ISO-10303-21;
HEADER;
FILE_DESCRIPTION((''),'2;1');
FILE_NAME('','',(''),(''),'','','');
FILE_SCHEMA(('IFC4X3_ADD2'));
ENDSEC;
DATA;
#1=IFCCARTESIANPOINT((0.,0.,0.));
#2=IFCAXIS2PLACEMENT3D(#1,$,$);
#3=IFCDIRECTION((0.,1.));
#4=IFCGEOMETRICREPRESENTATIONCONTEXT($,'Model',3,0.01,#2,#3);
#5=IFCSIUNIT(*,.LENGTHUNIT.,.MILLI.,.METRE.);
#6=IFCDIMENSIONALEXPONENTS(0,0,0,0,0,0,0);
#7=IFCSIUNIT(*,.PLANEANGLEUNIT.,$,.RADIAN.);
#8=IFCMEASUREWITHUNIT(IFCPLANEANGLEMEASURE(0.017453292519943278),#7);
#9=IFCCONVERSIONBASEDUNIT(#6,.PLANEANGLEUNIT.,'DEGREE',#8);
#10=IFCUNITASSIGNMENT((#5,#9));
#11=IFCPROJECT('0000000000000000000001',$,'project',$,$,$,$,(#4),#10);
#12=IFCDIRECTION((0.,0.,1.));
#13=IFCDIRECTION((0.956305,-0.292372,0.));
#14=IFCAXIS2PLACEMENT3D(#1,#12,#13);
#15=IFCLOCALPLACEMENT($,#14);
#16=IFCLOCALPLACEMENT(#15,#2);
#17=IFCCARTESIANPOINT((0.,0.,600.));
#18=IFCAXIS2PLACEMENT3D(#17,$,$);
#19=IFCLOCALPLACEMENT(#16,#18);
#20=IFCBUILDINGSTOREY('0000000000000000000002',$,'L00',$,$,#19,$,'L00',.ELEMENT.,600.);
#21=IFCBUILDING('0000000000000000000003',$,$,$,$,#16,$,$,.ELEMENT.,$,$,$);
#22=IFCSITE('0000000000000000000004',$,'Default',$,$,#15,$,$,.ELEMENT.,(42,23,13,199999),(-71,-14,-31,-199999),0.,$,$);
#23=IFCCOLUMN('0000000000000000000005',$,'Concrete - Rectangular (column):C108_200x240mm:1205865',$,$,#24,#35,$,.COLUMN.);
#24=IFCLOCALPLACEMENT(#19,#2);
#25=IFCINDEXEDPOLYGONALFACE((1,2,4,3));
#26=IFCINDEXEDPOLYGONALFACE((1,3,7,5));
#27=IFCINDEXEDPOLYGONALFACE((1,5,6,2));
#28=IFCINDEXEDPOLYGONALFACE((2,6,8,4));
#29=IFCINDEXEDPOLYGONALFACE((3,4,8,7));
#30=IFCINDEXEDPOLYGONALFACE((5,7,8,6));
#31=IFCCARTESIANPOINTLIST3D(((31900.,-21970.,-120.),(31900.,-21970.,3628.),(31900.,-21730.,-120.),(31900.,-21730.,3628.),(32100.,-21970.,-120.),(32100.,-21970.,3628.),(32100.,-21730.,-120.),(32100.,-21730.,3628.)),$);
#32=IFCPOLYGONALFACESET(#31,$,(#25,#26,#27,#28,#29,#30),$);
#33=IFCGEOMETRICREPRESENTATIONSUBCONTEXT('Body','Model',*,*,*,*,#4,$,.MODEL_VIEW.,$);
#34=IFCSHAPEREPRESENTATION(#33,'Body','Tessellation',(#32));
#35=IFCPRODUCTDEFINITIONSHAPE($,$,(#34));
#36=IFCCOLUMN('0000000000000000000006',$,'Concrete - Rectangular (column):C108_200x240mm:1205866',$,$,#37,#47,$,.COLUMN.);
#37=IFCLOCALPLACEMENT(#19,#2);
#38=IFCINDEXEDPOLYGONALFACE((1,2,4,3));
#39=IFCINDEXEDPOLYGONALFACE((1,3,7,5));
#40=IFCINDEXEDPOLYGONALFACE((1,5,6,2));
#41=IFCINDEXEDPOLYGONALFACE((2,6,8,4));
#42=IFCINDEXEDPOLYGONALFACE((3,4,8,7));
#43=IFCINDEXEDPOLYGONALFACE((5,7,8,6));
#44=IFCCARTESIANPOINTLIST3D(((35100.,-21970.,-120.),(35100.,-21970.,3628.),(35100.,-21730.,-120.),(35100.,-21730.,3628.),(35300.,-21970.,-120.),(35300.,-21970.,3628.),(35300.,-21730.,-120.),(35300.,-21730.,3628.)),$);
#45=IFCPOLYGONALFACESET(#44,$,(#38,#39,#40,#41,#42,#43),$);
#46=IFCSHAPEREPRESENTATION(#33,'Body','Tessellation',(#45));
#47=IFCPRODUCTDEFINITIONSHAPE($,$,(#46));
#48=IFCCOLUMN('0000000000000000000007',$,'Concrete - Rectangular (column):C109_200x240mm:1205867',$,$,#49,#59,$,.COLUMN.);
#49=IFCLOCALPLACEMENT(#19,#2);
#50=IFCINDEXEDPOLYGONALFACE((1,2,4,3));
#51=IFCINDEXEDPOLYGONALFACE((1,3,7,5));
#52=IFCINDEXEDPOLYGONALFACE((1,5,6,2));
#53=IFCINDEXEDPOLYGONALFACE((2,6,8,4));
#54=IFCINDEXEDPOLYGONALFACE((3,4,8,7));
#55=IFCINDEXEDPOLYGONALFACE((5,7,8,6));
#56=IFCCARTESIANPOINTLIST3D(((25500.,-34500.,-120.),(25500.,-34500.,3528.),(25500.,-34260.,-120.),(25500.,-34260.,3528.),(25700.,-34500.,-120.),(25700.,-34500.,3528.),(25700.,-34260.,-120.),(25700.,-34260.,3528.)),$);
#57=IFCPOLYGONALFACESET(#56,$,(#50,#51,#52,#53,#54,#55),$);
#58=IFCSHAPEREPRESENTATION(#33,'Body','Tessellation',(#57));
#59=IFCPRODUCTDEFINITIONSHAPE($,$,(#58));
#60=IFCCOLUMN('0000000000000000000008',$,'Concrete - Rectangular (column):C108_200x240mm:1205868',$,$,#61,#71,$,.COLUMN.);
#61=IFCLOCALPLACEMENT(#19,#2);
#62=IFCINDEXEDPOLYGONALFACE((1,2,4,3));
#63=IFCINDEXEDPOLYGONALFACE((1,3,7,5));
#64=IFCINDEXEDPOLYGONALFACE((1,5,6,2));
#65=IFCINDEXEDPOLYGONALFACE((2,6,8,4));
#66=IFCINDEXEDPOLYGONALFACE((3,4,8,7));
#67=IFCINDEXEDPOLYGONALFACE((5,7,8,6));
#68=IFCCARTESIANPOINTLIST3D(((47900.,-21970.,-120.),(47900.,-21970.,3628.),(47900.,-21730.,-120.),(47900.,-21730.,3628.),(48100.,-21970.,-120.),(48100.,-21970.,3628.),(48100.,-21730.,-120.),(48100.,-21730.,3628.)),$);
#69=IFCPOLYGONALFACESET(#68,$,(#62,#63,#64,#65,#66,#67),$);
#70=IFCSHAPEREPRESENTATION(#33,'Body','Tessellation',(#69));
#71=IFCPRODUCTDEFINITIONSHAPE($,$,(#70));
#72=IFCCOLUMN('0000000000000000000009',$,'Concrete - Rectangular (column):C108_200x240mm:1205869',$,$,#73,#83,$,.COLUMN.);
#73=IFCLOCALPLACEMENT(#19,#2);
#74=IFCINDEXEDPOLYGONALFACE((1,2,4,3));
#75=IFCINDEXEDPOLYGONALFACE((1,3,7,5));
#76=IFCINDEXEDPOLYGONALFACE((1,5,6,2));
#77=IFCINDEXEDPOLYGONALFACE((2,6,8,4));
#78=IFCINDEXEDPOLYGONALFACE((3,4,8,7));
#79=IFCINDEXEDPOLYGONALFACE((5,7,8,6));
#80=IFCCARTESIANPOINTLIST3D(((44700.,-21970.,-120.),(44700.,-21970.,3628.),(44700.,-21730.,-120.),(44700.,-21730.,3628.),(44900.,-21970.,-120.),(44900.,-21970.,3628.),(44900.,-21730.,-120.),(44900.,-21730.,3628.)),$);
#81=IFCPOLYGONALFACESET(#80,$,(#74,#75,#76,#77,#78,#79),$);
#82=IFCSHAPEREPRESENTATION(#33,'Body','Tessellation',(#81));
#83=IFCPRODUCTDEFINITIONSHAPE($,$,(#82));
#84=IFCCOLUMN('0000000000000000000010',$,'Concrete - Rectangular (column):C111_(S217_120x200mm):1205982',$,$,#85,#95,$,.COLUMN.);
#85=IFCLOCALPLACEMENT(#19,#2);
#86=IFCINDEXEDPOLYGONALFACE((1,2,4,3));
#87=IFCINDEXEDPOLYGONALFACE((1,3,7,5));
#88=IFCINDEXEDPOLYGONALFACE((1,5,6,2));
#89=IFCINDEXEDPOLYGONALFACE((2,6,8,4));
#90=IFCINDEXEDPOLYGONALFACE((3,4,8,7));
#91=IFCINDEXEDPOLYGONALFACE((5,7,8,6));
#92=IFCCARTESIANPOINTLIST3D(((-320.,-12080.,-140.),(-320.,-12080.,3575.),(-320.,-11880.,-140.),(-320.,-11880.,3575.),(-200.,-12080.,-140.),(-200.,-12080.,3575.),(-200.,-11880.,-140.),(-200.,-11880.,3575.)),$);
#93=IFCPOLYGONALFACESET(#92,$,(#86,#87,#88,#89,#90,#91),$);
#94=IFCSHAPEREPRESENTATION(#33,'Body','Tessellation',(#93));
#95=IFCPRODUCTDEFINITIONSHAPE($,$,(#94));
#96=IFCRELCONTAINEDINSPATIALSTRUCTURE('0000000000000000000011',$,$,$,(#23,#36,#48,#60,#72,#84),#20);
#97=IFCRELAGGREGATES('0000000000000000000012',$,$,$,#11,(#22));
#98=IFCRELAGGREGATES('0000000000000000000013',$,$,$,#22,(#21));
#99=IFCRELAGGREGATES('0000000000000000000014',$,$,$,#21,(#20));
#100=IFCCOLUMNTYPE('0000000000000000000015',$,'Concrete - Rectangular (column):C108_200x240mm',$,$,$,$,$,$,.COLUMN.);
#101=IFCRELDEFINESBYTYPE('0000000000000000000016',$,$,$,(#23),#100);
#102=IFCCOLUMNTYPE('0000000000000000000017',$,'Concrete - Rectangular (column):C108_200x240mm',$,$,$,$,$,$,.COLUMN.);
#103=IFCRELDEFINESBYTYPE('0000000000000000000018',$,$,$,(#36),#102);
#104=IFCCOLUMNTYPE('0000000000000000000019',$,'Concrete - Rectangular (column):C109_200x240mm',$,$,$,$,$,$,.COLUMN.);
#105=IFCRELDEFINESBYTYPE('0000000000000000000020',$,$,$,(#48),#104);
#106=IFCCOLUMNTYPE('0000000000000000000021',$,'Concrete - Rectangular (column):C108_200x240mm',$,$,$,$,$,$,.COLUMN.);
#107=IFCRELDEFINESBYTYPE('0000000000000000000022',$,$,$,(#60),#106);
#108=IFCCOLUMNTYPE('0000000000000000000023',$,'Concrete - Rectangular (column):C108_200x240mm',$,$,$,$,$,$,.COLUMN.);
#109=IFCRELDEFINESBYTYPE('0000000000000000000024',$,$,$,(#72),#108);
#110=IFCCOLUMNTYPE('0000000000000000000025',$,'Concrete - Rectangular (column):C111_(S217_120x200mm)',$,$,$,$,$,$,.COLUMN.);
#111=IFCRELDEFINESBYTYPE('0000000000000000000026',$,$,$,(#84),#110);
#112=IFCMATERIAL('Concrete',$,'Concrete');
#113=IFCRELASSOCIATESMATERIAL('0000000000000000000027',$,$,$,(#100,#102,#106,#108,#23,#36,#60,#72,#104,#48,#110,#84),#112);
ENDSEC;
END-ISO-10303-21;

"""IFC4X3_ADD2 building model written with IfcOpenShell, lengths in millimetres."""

from ifc_helpers import new_model, entity, si_unit, converted_unit, direction, frame, frame_2d, origin, origin_2d_with_axis, place, context, subcontext, project, spatial, rectangle, extrude, source, transform, mapped, material, material_profile, profile_set, profile_usage, type_object, type_shapes, element, save


model = new_model("IFC4X3_ADD2")

# Units and contexts
model_context = context("Model", 3, precision=0.01, world=origin(), true_north=direction((0.0, 1.0)))
body_context = subcontext(model_context, "Body", "Model", "MODEL_VIEW")
ifc_project = project(units=[si_unit("LENGTHUNIT", "METRE", prefix="MILLI"), converted_unit("PLANEANGLEUNIT", "DEGREE", entity("IfcPlaneAngleMeasure", 0.017453292519943278), si_unit("PLANEANGLEUNIT", "RADIAN"), dimensions=[0, 0, 0, 0, 0, 0, 0])], contexts=[model_context])

# Site, building, storey
site_placement = place(None, frame((0.0, 0.0, 0.0), z_axis=(0.0, 0.0, 1.0), x_axis=(0.956305, -0.292372, 0.0)))
site = spatial("IfcSite", under=ifc_project, at=site_placement, Name="Default", CompositionType="ELEMENT", RefLatitude=(42, 23, 13, 199999), RefLongitude=(-71, -14, -31, -199999), RefElevation=0.0)
building_placement = place(site_placement, origin())
building = spatial("IfcBuilding", under=site, at=building_placement, CompositionType="ELEMENT")
storey_placement = place(building_placement, frame((0.0, 0.0, 600.0)))
storey = spatial("IfcBuildingStorey", under=building, at=storey_placement, Name="L00", LongName="L00", CompositionType="ELEMENT", Elevation=600.0)

# Columns
ifc_material_1 = material(Name="Concrete", Category="Concrete")
ifc_material_profile_1 = material_profile(ifc_material_1, rectangle(XDim=200.0, YDim=240.0, at=frame_2d((0.0, 0.0), x_axis=(1.0, 0.0))), Name="C108_200x240mm")
ifc_profile_set_1 = profile_set([ifc_material_profile_1], Name="C108_200x240mm")
ifc_profile_usage_1 = profile_usage(ifc_profile_set_1)
column_type_1 = type_object("IfcColumnType", Name="Concrete - Rectangular (column):C108_200x240mm", PredefinedType="COLUMN", material=ifc_profile_set_1)
shared_shape_1 = source(origin(), body_context, "Body", "SweptSolid", [
    extrude(rectangle(XDim=200.0, YDim=240.0, at=frame_2d((0.0, 0.0), x_axis=(1.0, 0.0))), frame((32000.0, -21850.0, 480.0), z_axis=(0.0, 0.0, 1.0), x_axis=(-1.0, 0.0, 0.0)), (0.0, 0.0, 1.0), 3748.0),
])
type_shapes(column_type_1, [shared_shape_1])
column_1_placement = place(storey_placement, frame((0.0, 0.0, -600.0)))
element("IfcColumn", 1, at=column_1_placement, inside=storey, type_object=column_type_1, material=ifc_profile_usage_1, Name="Concrete - Rectangular (column):C108_200x240mm:1205865", PredefinedType="COLUMN", context=body_context, shape_type="MappedRepresentation", body=[
    mapped(shared_shape_1, transform((0.0, 0.0, 0.0), scale=1.0)),
])
column_type_2 = type_object("IfcColumnType", Name="Concrete - Rectangular (column):C108_200x240mm", PredefinedType="COLUMN", material=ifc_profile_set_1)
shared_shape_2 = source(origin(), body_context, "Body", "SweptSolid", [
    extrude(rectangle(XDim=200.0, YDim=240.0, at=frame_2d((0.0, 0.0), x_axis=(1.0, 0.0))), frame((35200.0, -21850.0, 480.0), z_axis=(0.0, 0.0, 1.0), x_axis=(-1.0, 0.0, 0.0)), (0.0, 0.0, 1.0), 3748.0),
])
type_shapes(column_type_2, [shared_shape_2])
column_2_placement = place(storey_placement, frame((0.0, 0.0, -600.0)))
element("IfcColumn", 2, at=column_2_placement, inside=storey, type_object=column_type_2, material=ifc_profile_usage_1, Name="Concrete - Rectangular (column):C108_200x240mm:1205866", PredefinedType="COLUMN", context=body_context, shape_type="MappedRepresentation", body=[
    mapped(shared_shape_2, transform((0.0, 0.0, 0.0), scale=1.0)),
])
ifc_material_profile_2 = material_profile(ifc_material_1, rectangle(XDim=200.0, YDim=240.0, at=frame_2d((0.0, 0.0), x_axis=(1.0, 0.0))), Name="C109_200x240mm")
ifc_profile_set_2 = profile_set([ifc_material_profile_2], Name="C109_200x240mm")
ifc_profile_usage_2 = profile_usage(ifc_profile_set_2)
column_type_3 = type_object("IfcColumnType", Name="Concrete - Rectangular (column):C109_200x240mm", PredefinedType="COLUMN", material=ifc_profile_set_2)
shared_shape_3 = source(origin(), body_context, "Body", "SweptSolid", [
    extrude(rectangle(XDim=200.0, YDim=240.0, at=frame_2d((0.0, 0.0), x_axis=(1.0, 0.0))), frame((25600.0, -34380.0, 480.0), z_axis=(0.0, 0.0, 1.0), x_axis=(-1.0, 0.0, 0.0)), (0.0, 0.0, 1.0), 3648.0),
])
type_shapes(column_type_3, [shared_shape_3])
column_3_placement = place(storey_placement, frame((0.0, 0.0, -600.0)))
element("IfcColumn", 3, at=column_3_placement, inside=storey, type_object=column_type_3, material=ifc_profile_usage_2, Name="Concrete - Rectangular (column):C109_200x240mm:1205867", PredefinedType="COLUMN", context=body_context, shape_type="MappedRepresentation", body=[
    mapped(shared_shape_3, transform((0.0, 0.0, 0.0), scale=1.0)),
])
column_type_4 = type_object("IfcColumnType", Name="Concrete - Rectangular (column):C108_200x240mm", PredefinedType="COLUMN", material=ifc_profile_set_1)
shared_shape_4 = source(origin(), body_context, "Body", "SweptSolid", [
    extrude(rectangle(XDim=200.0, YDim=240.0, at=frame_2d((0.0, 0.0), x_axis=(1.0, 0.0))), frame((48000.0, -21850.0, 480.0), z_axis=(0.0, 0.0, 1.0), x_axis=(-1.0, 0.0, 0.0)), (0.0, 0.0, 1.0), 3748.0),
])
type_shapes(column_type_4, [shared_shape_4])
column_4_placement = place(storey_placement, frame((0.0, 0.0, -600.0)))
element("IfcColumn", 4, at=column_4_placement, inside=storey, type_object=column_type_4, material=ifc_profile_usage_1, Name="Concrete - Rectangular (column):C108_200x240mm:1205868", PredefinedType="COLUMN", context=body_context, shape_type="MappedRepresentation", body=[
    mapped(shared_shape_4, transform((0.0, 0.0, 0.0), scale=1.0)),
])
column_type_5 = type_object("IfcColumnType", Name="Concrete - Rectangular (column):C108_200x240mm", PredefinedType="COLUMN", material=ifc_profile_set_1)
shared_shape_5 = source(origin(), body_context, "Body", "SweptSolid", [
    extrude(rectangle(XDim=200.0, YDim=240.0, at=frame_2d((0.0, 0.0), x_axis=(1.0, 0.0))), frame((44800.0, -21850.0, 480.0), z_axis=(0.0, 0.0, 1.0), x_axis=(-1.0, 0.0, 0.0)), (0.0, 0.0, 1.0), 3748.0),
])
type_shapes(column_type_5, [shared_shape_5])
column_5_placement = place(storey_placement, frame((0.0, 0.0, -600.0)))
element("IfcColumn", 5, at=column_5_placement, inside=storey, type_object=column_type_5, material=ifc_profile_usage_1, Name="Concrete - Rectangular (column):C108_200x240mm:1205869", PredefinedType="COLUMN", context=body_context, shape_type="MappedRepresentation", body=[
    mapped(shared_shape_5, transform((0.0, 0.0, 0.0), scale=1.0)),
])
ifc_material_profile_3 = material_profile(ifc_material_1, rectangle(XDim=120.0, YDim=200.0, at=frame_2d((0.0, 0.0), x_axis=(1.0, 0.0))), Name="C111_(S217_120x200mm)")
ifc_profile_set_3 = profile_set([ifc_material_profile_3], Name="C111_(S217_120x200mm)")
ifc_profile_usage_3 = profile_usage(ifc_profile_set_3)
column_type_6 = type_object("IfcColumnType", Name="Concrete - Rectangular (column):C111_(S217_120x200mm)", PredefinedType="COLUMN", material=ifc_profile_set_3)
shared_shape_6 = source(origin(), body_context, "Body", "SweptSolid", [
    extrude(rectangle(XDim=120.0, YDim=200.0, at=origin_2d_with_axis()), frame((0.0, 0.0, 460.0), z_axis=(0.0, 0.0, 1.0), x_axis=(-1.0, 0.0, 0.0)), (0.0, 0.0, 1.0), 3715.0),
])
type_shapes(column_type_6, [shared_shape_6])
column_6_placement = place(storey_placement, frame((-260.0, -11980.0, -600.0)))
element("IfcColumn", 6, at=column_6_placement, inside=storey, type_object=column_type_6, material=ifc_profile_usage_3, Name="Concrete - Rectangular (column):C111_(S217_120x200mm):1205982", PredefinedType="COLUMN", context=body_context, shape_type="MappedRepresentation", body=[
    mapped(shared_shape_6, transform((0.0, 0.0, 0.0), scale=1.0)),
])

save(model, "model.ifc")
